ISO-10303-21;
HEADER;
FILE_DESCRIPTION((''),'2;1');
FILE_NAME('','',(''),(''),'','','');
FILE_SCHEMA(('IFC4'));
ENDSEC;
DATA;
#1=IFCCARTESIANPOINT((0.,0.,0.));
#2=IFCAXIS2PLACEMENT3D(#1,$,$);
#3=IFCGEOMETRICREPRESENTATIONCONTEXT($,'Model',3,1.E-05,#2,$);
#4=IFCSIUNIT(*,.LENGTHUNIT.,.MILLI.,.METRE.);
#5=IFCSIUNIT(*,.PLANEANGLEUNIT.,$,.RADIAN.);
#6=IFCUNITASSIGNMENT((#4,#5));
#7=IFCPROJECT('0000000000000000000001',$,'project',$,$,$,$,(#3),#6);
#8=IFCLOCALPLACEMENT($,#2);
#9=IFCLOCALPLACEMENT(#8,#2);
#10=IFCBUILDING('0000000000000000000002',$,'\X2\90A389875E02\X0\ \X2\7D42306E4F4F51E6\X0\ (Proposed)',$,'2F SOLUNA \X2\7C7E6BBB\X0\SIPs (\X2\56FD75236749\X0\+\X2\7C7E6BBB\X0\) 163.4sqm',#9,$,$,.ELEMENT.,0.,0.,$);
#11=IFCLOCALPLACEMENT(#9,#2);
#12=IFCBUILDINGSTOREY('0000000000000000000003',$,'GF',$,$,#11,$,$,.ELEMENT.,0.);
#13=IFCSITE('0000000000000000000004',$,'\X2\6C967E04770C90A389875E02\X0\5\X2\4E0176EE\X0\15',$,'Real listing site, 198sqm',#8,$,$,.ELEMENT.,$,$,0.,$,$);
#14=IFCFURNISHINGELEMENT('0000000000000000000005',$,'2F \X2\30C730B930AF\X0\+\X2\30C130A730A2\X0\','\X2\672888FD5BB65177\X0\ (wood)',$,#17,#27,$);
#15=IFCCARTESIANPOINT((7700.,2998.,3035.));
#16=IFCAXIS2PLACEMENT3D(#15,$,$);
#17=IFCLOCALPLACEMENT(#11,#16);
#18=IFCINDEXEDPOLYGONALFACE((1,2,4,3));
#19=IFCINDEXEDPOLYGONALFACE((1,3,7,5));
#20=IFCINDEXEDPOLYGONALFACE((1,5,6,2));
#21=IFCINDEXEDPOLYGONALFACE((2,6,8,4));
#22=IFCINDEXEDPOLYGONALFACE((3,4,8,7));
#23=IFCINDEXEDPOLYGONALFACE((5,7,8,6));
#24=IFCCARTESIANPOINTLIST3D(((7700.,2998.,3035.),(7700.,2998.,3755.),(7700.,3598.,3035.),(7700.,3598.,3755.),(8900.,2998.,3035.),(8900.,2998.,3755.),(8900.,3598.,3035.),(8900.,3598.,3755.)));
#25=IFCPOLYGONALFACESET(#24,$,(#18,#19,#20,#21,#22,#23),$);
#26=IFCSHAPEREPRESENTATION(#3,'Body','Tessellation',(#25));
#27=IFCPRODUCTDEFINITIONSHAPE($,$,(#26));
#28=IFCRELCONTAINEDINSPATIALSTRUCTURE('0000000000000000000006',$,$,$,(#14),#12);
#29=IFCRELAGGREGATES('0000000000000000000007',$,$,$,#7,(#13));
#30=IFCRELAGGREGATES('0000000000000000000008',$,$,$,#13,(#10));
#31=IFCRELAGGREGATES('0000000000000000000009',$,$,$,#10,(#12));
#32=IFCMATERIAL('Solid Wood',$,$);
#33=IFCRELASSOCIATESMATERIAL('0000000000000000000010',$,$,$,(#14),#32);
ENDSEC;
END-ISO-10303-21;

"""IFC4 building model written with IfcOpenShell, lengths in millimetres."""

from ifc_helpers import new_model, si_unit, frame, frame_2d, origin, place, context, project, spatial, rectangle, extrude, material, element, save


model = new_model("IFC4")

# Units and contexts
model_context = context("Model", 3, precision=1e-05, world=origin())
ifc_project = project(units=[si_unit("LENGTHUNIT", "METRE", prefix="MILLI"), si_unit("PLANEANGLEUNIT", "RADIAN")], contexts=[model_context])

# Site, building, storey
site_placement = place(None, origin())
site = spatial("IfcSite", under=ifc_project, at=site_placement, Name="沖縄県那覇市5丁目15", ObjectType="Real listing site, 198sqm", CompositionType="ELEMENT", RefElevation=0.0)
building_placement = place(site_placement, origin())
building = spatial("IfcBuilding", under=site, at=building_placement, Name="那覇市 終の住処 (Proposed)", ObjectType="2F SOLUNA 籾殻SIPs (国産杉+籾殻) 163.4sqm", CompositionType="ELEMENT", ElevationOfRefHeight=0.0, ElevationOfTerrain=0.0)
storey_placement = place(building_placement, origin())
storey = spatial("IfcBuildingStorey", under=building, at=storey_placement, Name="GF", CompositionType="ELEMENT", Elevation=0.0)

# Shared definitions
ifc_material_1 = material(Name="Solid Wood")

# Furnishing element
furnishing_1_placement = place(storey_placement, frame((7700.0, 2998.0, 3035.0)))
element("IfcFurnishingElement", 1, at=furnishing_1_placement, inside=storey, material=ifc_material_1, Name="2F デスク+チェア", Description="木製家具 (wood)", context=model_context, shape_type="SweptSolid", body=[
    extrude(rectangle(XDim=1200.0, YDim=600.0, at=frame_2d((600.0, 300.0))), frame((7700.0, 2998.0, 3035.0)), (0.0, 0.0, 1.0), 720.0),
])

save(model, "model.ifc")
